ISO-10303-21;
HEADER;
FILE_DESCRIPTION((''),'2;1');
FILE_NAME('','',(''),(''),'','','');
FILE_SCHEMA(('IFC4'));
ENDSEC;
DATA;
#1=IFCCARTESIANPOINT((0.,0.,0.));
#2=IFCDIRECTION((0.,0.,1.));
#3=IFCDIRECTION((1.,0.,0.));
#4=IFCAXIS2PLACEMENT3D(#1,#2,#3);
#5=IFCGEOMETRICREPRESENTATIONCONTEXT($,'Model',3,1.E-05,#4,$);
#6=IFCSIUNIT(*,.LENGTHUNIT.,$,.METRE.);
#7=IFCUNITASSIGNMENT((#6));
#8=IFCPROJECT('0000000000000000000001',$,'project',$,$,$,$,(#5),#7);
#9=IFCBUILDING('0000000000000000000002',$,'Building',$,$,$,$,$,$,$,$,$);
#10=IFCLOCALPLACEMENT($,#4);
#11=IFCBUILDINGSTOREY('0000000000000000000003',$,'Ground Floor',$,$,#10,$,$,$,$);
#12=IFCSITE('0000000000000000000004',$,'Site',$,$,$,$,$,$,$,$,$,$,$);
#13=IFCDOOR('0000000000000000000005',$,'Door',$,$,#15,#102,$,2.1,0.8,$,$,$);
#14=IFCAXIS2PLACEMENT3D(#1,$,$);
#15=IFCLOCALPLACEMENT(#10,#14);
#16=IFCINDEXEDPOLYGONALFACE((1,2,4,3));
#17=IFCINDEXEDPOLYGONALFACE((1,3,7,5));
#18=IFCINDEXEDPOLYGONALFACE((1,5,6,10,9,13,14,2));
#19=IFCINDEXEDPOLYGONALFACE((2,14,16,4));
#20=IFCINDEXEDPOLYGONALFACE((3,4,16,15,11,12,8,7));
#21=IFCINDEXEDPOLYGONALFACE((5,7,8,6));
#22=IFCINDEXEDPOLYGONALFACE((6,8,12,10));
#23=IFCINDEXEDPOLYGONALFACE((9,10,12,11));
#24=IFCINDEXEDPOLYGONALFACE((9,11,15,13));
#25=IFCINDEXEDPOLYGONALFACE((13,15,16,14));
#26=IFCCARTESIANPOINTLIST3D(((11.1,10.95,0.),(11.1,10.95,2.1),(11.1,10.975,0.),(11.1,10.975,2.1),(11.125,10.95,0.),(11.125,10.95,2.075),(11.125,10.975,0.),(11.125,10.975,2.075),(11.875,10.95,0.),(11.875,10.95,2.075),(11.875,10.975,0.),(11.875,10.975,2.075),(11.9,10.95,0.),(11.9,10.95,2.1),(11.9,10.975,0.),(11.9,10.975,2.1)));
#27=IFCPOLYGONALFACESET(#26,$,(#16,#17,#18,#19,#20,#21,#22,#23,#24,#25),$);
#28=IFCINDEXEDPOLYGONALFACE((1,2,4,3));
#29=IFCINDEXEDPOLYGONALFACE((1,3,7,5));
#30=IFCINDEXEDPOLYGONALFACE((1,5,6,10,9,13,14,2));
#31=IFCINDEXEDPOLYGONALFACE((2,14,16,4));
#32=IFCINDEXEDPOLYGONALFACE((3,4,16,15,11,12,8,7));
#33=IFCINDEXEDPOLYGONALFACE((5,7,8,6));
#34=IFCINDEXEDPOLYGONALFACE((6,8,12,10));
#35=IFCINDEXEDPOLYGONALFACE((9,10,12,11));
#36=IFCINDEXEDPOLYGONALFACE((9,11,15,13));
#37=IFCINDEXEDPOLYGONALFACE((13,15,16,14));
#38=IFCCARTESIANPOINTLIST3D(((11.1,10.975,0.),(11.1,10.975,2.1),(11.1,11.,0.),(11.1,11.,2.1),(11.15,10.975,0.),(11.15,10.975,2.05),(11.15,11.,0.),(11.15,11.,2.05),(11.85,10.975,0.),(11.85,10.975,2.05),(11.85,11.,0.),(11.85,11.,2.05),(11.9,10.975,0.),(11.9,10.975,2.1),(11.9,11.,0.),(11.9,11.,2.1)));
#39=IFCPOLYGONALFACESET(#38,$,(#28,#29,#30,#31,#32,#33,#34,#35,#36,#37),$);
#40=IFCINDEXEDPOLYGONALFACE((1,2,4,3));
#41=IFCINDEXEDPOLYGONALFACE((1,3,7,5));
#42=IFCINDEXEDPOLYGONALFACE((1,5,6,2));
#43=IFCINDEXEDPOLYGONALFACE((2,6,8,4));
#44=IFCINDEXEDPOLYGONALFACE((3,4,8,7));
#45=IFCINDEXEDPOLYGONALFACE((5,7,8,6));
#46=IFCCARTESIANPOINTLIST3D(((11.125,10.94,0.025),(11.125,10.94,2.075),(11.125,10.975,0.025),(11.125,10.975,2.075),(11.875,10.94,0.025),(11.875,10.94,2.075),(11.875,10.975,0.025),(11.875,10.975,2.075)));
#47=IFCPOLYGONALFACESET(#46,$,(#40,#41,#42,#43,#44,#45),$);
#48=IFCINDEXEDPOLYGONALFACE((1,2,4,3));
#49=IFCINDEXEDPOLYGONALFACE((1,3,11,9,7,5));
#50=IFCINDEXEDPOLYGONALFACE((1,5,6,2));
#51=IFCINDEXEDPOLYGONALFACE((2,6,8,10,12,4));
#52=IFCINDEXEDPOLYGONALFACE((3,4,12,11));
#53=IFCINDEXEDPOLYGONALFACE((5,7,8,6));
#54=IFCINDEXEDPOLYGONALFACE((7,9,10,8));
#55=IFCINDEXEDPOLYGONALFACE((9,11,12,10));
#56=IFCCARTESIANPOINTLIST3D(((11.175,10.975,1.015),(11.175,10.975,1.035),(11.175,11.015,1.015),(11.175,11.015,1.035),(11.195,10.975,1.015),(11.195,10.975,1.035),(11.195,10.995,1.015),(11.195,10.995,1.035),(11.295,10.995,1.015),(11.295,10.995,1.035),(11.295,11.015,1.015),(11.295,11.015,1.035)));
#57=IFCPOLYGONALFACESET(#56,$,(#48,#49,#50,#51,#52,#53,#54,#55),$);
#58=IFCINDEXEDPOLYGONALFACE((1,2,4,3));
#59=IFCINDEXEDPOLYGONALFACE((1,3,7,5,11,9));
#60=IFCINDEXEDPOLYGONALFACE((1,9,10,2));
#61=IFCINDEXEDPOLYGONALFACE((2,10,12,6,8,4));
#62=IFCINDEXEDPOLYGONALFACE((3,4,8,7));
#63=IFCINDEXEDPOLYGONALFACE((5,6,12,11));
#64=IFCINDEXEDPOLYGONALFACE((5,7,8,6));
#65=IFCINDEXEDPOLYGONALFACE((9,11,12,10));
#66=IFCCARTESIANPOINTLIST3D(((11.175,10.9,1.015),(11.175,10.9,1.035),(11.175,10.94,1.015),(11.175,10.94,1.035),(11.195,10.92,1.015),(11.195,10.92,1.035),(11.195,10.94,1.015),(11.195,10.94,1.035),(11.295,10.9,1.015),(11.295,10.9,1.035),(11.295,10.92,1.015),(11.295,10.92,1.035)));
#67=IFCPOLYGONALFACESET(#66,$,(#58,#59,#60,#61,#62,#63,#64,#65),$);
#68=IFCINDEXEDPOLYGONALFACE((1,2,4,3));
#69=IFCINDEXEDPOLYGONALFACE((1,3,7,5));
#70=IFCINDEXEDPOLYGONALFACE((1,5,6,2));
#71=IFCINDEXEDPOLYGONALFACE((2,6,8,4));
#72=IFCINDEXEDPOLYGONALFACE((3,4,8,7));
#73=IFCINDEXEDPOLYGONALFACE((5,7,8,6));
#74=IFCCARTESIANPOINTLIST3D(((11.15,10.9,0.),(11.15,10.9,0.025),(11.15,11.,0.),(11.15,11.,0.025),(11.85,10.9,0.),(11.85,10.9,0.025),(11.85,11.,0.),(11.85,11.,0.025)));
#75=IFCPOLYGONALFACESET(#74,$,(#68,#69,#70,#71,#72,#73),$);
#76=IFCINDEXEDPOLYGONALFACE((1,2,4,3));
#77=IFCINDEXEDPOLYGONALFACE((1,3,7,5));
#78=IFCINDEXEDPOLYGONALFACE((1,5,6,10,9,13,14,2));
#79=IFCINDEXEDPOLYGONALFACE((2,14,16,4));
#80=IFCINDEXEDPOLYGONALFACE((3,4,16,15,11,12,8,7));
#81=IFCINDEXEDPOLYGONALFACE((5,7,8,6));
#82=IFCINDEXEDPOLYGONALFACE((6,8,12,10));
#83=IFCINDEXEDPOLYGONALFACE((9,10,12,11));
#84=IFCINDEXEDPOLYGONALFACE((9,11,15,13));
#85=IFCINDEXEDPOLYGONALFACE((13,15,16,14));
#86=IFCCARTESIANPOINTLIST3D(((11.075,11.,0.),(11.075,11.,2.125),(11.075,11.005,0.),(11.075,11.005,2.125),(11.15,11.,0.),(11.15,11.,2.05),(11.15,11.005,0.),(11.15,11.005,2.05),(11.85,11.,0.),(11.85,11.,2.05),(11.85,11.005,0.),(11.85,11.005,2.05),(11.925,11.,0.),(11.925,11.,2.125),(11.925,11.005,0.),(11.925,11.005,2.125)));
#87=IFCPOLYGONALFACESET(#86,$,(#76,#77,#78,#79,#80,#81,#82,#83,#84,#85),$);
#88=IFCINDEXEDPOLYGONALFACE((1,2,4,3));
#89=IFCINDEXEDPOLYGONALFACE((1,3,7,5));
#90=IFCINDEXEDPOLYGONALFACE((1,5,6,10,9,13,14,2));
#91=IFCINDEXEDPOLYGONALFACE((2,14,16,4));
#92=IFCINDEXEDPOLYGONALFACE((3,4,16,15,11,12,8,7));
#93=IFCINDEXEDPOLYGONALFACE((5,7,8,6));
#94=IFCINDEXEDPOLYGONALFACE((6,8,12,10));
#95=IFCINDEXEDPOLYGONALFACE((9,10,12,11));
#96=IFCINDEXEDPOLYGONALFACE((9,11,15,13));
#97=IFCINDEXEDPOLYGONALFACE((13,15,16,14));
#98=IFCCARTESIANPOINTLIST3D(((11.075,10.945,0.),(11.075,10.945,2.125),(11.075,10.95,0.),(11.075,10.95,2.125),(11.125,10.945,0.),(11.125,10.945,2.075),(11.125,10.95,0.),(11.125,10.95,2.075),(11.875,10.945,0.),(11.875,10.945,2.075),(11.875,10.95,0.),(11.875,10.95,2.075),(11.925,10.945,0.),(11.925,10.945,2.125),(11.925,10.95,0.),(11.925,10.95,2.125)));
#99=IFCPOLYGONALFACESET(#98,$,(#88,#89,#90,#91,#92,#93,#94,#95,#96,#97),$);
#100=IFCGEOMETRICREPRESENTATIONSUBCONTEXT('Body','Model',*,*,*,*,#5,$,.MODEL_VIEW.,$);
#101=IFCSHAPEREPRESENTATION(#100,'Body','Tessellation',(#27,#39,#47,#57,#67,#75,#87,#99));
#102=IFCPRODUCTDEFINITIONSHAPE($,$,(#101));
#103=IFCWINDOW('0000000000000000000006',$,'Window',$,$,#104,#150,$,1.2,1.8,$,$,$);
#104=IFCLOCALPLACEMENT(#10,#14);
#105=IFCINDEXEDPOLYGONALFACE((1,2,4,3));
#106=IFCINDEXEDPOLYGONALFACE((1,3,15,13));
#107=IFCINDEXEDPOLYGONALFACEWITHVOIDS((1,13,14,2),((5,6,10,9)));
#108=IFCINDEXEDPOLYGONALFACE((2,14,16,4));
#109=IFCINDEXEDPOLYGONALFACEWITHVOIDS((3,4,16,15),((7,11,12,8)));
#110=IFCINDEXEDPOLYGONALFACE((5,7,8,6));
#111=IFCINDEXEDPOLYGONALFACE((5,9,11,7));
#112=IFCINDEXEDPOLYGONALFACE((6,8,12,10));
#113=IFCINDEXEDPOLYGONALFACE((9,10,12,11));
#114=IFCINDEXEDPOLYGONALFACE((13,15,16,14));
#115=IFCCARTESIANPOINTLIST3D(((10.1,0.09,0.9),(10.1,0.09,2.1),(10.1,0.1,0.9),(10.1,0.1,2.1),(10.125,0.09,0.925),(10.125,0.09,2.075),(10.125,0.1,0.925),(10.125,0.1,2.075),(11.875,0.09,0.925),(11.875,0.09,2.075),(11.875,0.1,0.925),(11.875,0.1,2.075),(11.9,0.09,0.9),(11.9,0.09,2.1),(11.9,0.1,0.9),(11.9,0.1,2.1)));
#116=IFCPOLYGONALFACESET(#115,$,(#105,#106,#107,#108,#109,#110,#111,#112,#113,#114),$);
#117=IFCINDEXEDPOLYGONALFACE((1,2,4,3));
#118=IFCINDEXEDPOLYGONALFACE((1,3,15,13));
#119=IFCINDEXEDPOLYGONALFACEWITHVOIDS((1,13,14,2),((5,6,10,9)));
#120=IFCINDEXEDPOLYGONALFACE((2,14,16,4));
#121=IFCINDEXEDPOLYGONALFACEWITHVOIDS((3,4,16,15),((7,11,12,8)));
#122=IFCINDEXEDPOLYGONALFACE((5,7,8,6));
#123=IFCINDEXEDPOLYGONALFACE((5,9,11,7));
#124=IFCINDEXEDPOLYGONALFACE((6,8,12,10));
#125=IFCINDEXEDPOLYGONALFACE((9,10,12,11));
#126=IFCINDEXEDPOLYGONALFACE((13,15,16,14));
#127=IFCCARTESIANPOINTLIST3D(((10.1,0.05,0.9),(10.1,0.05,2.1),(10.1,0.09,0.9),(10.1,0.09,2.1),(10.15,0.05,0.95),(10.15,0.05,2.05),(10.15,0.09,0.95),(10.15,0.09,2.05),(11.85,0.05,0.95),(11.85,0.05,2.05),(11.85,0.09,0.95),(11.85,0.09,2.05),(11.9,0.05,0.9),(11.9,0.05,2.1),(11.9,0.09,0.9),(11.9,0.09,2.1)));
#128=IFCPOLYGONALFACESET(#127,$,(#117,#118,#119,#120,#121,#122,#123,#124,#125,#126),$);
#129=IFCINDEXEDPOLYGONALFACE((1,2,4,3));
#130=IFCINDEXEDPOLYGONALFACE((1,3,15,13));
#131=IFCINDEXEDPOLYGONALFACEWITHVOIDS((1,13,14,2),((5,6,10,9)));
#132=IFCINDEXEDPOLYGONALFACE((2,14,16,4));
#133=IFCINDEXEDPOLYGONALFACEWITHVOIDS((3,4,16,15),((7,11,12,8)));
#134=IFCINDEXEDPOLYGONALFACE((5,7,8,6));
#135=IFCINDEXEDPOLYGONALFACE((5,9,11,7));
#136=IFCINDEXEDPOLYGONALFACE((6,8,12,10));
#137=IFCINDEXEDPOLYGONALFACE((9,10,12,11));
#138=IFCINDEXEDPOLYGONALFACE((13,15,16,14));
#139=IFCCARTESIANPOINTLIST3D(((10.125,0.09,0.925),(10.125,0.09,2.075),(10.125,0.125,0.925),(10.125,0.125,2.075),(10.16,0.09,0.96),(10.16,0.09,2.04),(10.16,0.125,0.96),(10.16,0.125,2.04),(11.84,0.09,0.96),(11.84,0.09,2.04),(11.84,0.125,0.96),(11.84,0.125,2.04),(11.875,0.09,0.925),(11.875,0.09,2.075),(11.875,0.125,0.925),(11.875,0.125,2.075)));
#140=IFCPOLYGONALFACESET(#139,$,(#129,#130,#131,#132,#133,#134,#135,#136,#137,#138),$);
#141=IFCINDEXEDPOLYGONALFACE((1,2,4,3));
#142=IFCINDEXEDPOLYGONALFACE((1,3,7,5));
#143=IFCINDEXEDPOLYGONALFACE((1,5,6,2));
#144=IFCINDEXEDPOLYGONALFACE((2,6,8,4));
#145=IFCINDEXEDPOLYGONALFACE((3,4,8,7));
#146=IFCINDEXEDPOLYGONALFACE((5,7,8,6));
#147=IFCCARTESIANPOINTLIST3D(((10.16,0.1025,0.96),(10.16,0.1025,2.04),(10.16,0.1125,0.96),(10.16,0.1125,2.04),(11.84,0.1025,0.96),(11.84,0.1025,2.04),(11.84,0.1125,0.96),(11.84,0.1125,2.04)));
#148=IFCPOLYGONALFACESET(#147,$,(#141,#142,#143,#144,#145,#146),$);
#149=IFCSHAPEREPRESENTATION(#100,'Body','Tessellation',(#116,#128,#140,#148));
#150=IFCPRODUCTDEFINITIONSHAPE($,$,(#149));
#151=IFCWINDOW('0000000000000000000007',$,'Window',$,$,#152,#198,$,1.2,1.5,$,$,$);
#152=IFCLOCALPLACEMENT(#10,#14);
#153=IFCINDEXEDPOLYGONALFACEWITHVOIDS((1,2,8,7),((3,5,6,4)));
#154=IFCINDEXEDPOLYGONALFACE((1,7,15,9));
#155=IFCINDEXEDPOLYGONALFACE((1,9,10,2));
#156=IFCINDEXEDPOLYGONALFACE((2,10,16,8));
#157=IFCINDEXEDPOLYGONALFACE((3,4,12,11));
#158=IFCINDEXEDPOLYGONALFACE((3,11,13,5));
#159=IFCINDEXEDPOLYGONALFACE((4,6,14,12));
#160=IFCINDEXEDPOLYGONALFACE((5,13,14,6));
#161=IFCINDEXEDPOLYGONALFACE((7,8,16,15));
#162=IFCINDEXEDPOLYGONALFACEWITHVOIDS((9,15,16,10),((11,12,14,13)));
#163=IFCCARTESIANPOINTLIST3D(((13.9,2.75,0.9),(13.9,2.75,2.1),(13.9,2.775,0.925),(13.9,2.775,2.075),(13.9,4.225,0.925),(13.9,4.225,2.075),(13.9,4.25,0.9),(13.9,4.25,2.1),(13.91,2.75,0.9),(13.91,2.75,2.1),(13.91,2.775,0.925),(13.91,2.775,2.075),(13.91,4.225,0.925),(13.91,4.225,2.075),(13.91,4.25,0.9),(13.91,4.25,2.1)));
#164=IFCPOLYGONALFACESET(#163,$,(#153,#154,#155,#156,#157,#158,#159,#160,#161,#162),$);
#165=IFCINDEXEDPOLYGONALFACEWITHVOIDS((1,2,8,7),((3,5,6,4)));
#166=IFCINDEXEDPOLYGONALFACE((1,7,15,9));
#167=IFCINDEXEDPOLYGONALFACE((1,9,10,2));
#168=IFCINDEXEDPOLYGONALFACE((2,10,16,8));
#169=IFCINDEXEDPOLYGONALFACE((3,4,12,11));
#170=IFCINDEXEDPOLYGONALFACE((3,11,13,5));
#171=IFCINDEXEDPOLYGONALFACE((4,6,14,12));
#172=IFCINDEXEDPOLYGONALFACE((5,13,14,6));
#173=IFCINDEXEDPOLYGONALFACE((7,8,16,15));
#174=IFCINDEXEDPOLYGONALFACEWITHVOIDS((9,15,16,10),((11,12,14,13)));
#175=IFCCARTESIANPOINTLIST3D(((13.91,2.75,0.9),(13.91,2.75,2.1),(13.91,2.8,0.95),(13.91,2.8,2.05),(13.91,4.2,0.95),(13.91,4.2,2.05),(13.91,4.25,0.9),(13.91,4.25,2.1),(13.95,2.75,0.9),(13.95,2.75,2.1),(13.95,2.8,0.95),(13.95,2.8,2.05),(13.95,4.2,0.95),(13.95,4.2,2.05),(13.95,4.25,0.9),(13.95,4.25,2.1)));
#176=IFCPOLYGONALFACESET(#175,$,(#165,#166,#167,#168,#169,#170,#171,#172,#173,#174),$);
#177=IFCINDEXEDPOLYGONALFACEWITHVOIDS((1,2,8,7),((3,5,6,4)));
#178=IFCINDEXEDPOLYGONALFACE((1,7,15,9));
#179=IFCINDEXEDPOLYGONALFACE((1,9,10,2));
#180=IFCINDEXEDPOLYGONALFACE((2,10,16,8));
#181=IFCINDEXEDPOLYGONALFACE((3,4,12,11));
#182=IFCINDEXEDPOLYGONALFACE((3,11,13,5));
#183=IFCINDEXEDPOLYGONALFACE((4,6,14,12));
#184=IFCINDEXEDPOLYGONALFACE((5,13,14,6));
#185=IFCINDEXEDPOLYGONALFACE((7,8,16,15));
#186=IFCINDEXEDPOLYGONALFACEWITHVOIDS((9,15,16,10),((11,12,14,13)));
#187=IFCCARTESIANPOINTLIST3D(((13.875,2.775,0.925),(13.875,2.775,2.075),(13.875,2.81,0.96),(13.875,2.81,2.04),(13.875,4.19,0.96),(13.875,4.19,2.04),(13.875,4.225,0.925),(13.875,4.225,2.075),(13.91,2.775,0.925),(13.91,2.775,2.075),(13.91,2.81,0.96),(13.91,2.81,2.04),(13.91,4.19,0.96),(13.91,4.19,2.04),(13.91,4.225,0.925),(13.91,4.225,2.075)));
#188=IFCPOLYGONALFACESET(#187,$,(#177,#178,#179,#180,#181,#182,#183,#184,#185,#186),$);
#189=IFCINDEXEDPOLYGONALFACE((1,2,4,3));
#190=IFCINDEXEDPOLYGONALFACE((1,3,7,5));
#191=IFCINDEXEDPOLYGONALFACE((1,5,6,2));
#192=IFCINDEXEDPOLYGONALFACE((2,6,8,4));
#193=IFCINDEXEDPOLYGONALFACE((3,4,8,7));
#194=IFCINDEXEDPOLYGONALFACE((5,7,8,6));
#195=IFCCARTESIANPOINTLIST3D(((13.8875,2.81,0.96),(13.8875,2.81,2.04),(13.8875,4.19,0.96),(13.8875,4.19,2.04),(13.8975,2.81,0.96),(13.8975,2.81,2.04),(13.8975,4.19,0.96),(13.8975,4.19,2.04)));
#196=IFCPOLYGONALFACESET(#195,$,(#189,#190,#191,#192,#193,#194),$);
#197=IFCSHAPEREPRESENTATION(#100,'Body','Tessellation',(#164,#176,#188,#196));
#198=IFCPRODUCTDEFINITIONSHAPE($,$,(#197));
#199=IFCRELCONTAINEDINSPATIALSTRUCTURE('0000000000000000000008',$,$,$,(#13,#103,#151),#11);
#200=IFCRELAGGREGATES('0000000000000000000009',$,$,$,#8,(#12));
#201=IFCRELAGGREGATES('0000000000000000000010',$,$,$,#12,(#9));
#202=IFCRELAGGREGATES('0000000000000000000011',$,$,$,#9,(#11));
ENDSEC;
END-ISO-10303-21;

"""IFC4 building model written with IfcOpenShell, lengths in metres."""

from ifc_helpers import new_model, si_unit, frame, origin_with_axes, place, context, subcontext, project, spatial, line, indexed_curve, outline, extrude, element, save


model = new_model("IFC4")

# Units and contexts
model_context = context("Model", 3, precision=1e-05, world=origin_with_axes())
body_context = subcontext(model_context, "Body", "Model", "MODEL_VIEW")
ifc_project = project(units=[si_unit("LENGTHUNIT", "METRE")], contexts=[model_context])

# Site, building, storey
site = spatial("IfcSite", under=ifc_project, Name="Site")
building = spatial("IfcBuilding", under=site, Name="Building")
storey_placement = place(None, origin_with_axes())
storey = spatial("IfcBuildingStorey", under=building, at=storey_placement, Name="Ground Floor")

# Door
door_1_placement = place(storey_placement, frame((11.9, 11.0, 0.0), z_axis=(0.0, 0.0, 1.0), x_axis=(-1.0, 0.0, 0.0)))
element("IfcDoor", 1, at=door_1_placement, inside=storey, Name="Door", OverallHeight=2.1, OverallWidth=0.8, context=body_context, shape_type="SweptSolid", body=[
    extrude(outline(indexed_curve([(0.0, 0.0), (0.0, 2.1), (0.8, 2.1), (0.8, 0.0), (0.775, 0.0), (0.775, 2.075), (0.025, 2.075), (0.025, 0.0)], segments=[line(1, 2, 3, 4, 5, 6, 7, 8, 1)])), frame((0.0, 0.025, 0.0), z_axis=(0.0, -1.0, 0.0), x_axis=(1.0, 0.0, 0.0)), (0.0, 0.0, -1.0), 0.025),
    extrude(outline(indexed_curve([(0.0, 0.0), (0.0, 2.1), (0.8, 2.1), (0.8, 0.0), (0.75, 0.0), (0.75, 2.05), (0.05, 2.05), (0.05, 0.0)], segments=[line(1, 2, 3, 4, 5, 6, 7, 8, 1)])), frame((0.0, 0.0, 0.0), z_axis=(0.0, -1.0, 0.0), x_axis=(1.0, 0.0, 0.0)), (0.0, 0.0, -1.0), 0.025),
    extrude(outline(indexed_curve([(0.0, 0.0), (0.75, 0.0), (0.75, 0.035), (0.0, 0.035)], segments=[line(1, 2, 3, 4, 1)])), frame((0.025, 0.025, 0.025), z_axis=(0.0, 0.0, 1.0), x_axis=(1.0, 0.0, 0.0)), (0.0, 0.0, 1.0), 2.05),
    extrude(outline(indexed_curve([(0.0, 0.0), (0.0, -0.04), (-0.12, -0.04), (-0.12, -0.02), (-0.02, -0.02), (-0.02, 0.0)], segments=[line(1, 2, 3, 4, 5, 6, 1)])), frame((0.725, 0.025, 1.015), z_axis=(0.0, 0.0, 1.0), x_axis=(1.0, 0.0, 0.0)), (0.0, 0.0, 1.0), 0.02),
    extrude(outline(indexed_curve([(0.0, 0.0), (0.0, 0.04), (-0.12, 0.04), (-0.12, 0.02), (-0.02, 0.02), (-0.02, 0.0)], segments=[line(1, 2, 3, 4, 5, 6, 1)])), frame((0.725, 0.06, 1.015), z_axis=(0.0, 0.0, 1.0), x_axis=(1.0, 0.0, 0.0)), (0.0, 0.0, 1.0), 0.02),
    extrude(outline(indexed_curve([(0.0, 0.0), (0.7, 0.0), (0.7, 0.1), (0.0, 0.1)], segments=[line(1, 2, 3, 4, 1)])), frame((0.05, 0.0, 0.0), z_axis=(0.0, 0.0, 1.0), x_axis=(1.0, 0.0, 0.0)), (0.0, 0.0, 1.0), 0.025),
    extrude(outline(indexed_curve([(0.0, 0.0), (0.0, 2.125), (0.85, 2.125), (0.85, 0.0), (0.775, 0.0), (0.775, 2.05), (0.075, 2.05), (0.075, 0.0)], segments=[line(1, 2, 3, 4, 5, 6, 7, 8, 1)])), frame((-0.025, -0.005, 0.0), z_axis=(0.0, -1.0, 0.0), x_axis=(1.0, 0.0, 0.0)), (0.0, 0.0, -1.0), 0.005),
    extrude(outline(indexed_curve([(0.0, 0.0), (0.0, 2.125), (0.85, 2.125), (0.85, 0.0), (0.8, 0.0), (0.8, 2.075), (0.05, 2.075), (0.05, 0.0)], segments=[line(1, 2, 3, 4, 5, 6, 7, 8, 1)])), frame((-0.025, 0.05, 0.0), z_axis=(0.0, -1.0, 0.0), x_axis=(1.0, 0.0, 0.0)), (0.0, 0.0, -1.0), 0.005),
])

# Windows
window_1_placement = place(storey_placement, frame((10.1, 0.0, 0.9), z_axis=(0.0, 0.0, 1.0), x_axis=(1.0, 0.0, 0.0)))
element("IfcWindow", 2, at=window_1_placement, inside=storey, Name="Window", OverallHeight=1.2, OverallWidth=1.8, context=body_context, shape_type="SweptSolid", body=[
    extrude(outline(indexed_curve([(0.0, 0.0), (1.8, 0.0), (1.8, 1.2), (0.0, 1.2)], segments=[line(1, 2, 3, 4, 1)]), holes=[indexed_curve([(0.025, 0.025), (1.775, 0.025), (1.775, 1.175), (0.025, 1.175)], segments=[line(1, 2, 3, 4, 1)])]), frame((0.0, 0.09, 0.0), z_axis=(0.0, -1.0, 0.0), x_axis=(1.0, 0.0, 0.0)), (0.0, 0.0, -1.0), 0.01),
    extrude(outline(indexed_curve([(0.0, 0.0), (1.8, 0.0), (1.8, 1.2), (0.0, 1.2)], segments=[line(1, 2, 3, 4, 1)]), holes=[indexed_curve([(0.05, 0.05), (1.75, 0.05), (1.75, 1.15), (0.05, 1.15)], segments=[line(1, 2, 3, 4, 1)])]), frame((0.0, 0.05, 0.0), z_axis=(0.0, -1.0, 0.0), x_axis=(1.0, 0.0, 0.0)), (0.0, 0.0, -1.0), 0.04),
    extrude(outline(indexed_curve([(0.0, 0.0), (1.75, 0.0), (1.75, 1.15), (0.0, 1.15)], segments=[line(1, 2, 3, 4, 1)]), holes=[indexed_curve([(0.035, 0.035), (1.715, 0.035), (1.715, 1.115), (0.035, 1.115)], segments=[line(1, 2, 3, 4, 1)])]), frame((0.025, 0.09, 0.025), z_axis=(0.0, -1.0, 0.0), x_axis=(1.0, 0.0, 0.0)), (0.0, 0.0, -1.0), 0.035),
    extrude(outline(indexed_curve([(0.035, 0.035), (1.715, 0.035), (1.715, 1.115), (0.035, 1.115)], segments=[line(1, 2, 3, 4, 1)])), frame((0.025, 0.1025, 0.025), z_axis=(0.0, -1.0, 0.0), x_axis=(1.0, 0.0, 0.0)), (0.0, 0.0, -1.0), 0.01),
])
for number, where, z_axis, x_axis, name in (
    (3, (14.0, 2.75, 0.9), (0.0, 0.0, 1.0), (0.0, 1.0, 0.0), "Window"),
):
    element("IfcWindow", number, at=place(storey_placement, frame(where, z_axis=z_axis, x_axis=x_axis)), inside=storey, Name=name, OverallHeight=1.2, OverallWidth=1.5, context=body_context, shape_type="SweptSolid", body=[
        extrude(outline(indexed_curve([(0.0, 0.0), (1.5, 0.0), (1.5, 1.2), (0.0, 1.2)], segments=[line(1, 2, 3, 4, 1)]), holes=[indexed_curve([(0.025, 0.025), (1.475, 0.025), (1.475, 1.175), (0.025, 1.175)], segments=[line(1, 2, 3, 4, 1)])]), frame((0.0, 0.09, 0.0), z_axis=(0.0, -1.0, 0.0), x_axis=(1.0, 0.0, 0.0)), (0.0, 0.0, -1.0), 0.01),
        extrude(outline(indexed_curve([(0.0, 0.0), (1.5, 0.0), (1.5, 1.2), (0.0, 1.2)], segments=[line(1, 2, 3, 4, 1)]), holes=[indexed_curve([(0.05, 0.05), (1.45, 0.05), (1.45, 1.15), (0.05, 1.15)], segments=[line(1, 2, 3, 4, 1)])]), frame((0.0, 0.05, 0.0), z_axis=(0.0, -1.0, 0.0), x_axis=(1.0, 0.0, 0.0)), (0.0, 0.0, -1.0), 0.04),
        extrude(outline(indexed_curve([(0.0, 0.0), (1.45, 0.0), (1.45, 1.15), (0.0, 1.15)], segments=[line(1, 2, 3, 4, 1)]), holes=[indexed_curve([(0.035, 0.035), (1.415, 0.035), (1.415, 1.115), (0.035, 1.115)], segments=[line(1, 2, 3, 4, 1)])]), frame((0.025, 0.09, 0.025), z_axis=(0.0, -1.0, 0.0), x_axis=(1.0, 0.0, 0.0)), (0.0, 0.0, -1.0), 0.035),
        extrude(outline(indexed_curve([(0.035, 0.035), (1.415, 0.035), (1.415, 1.115), (0.035, 1.115)], segments=[line(1, 2, 3, 4, 1)])), frame((0.025, 0.1025, 0.025), z_axis=(0.0, -1.0, 0.0), x_axis=(1.0, 0.0, 0.0)), (0.0, 0.0, -1.0), 0.01),
    ])

save(model, "model.ifc")
